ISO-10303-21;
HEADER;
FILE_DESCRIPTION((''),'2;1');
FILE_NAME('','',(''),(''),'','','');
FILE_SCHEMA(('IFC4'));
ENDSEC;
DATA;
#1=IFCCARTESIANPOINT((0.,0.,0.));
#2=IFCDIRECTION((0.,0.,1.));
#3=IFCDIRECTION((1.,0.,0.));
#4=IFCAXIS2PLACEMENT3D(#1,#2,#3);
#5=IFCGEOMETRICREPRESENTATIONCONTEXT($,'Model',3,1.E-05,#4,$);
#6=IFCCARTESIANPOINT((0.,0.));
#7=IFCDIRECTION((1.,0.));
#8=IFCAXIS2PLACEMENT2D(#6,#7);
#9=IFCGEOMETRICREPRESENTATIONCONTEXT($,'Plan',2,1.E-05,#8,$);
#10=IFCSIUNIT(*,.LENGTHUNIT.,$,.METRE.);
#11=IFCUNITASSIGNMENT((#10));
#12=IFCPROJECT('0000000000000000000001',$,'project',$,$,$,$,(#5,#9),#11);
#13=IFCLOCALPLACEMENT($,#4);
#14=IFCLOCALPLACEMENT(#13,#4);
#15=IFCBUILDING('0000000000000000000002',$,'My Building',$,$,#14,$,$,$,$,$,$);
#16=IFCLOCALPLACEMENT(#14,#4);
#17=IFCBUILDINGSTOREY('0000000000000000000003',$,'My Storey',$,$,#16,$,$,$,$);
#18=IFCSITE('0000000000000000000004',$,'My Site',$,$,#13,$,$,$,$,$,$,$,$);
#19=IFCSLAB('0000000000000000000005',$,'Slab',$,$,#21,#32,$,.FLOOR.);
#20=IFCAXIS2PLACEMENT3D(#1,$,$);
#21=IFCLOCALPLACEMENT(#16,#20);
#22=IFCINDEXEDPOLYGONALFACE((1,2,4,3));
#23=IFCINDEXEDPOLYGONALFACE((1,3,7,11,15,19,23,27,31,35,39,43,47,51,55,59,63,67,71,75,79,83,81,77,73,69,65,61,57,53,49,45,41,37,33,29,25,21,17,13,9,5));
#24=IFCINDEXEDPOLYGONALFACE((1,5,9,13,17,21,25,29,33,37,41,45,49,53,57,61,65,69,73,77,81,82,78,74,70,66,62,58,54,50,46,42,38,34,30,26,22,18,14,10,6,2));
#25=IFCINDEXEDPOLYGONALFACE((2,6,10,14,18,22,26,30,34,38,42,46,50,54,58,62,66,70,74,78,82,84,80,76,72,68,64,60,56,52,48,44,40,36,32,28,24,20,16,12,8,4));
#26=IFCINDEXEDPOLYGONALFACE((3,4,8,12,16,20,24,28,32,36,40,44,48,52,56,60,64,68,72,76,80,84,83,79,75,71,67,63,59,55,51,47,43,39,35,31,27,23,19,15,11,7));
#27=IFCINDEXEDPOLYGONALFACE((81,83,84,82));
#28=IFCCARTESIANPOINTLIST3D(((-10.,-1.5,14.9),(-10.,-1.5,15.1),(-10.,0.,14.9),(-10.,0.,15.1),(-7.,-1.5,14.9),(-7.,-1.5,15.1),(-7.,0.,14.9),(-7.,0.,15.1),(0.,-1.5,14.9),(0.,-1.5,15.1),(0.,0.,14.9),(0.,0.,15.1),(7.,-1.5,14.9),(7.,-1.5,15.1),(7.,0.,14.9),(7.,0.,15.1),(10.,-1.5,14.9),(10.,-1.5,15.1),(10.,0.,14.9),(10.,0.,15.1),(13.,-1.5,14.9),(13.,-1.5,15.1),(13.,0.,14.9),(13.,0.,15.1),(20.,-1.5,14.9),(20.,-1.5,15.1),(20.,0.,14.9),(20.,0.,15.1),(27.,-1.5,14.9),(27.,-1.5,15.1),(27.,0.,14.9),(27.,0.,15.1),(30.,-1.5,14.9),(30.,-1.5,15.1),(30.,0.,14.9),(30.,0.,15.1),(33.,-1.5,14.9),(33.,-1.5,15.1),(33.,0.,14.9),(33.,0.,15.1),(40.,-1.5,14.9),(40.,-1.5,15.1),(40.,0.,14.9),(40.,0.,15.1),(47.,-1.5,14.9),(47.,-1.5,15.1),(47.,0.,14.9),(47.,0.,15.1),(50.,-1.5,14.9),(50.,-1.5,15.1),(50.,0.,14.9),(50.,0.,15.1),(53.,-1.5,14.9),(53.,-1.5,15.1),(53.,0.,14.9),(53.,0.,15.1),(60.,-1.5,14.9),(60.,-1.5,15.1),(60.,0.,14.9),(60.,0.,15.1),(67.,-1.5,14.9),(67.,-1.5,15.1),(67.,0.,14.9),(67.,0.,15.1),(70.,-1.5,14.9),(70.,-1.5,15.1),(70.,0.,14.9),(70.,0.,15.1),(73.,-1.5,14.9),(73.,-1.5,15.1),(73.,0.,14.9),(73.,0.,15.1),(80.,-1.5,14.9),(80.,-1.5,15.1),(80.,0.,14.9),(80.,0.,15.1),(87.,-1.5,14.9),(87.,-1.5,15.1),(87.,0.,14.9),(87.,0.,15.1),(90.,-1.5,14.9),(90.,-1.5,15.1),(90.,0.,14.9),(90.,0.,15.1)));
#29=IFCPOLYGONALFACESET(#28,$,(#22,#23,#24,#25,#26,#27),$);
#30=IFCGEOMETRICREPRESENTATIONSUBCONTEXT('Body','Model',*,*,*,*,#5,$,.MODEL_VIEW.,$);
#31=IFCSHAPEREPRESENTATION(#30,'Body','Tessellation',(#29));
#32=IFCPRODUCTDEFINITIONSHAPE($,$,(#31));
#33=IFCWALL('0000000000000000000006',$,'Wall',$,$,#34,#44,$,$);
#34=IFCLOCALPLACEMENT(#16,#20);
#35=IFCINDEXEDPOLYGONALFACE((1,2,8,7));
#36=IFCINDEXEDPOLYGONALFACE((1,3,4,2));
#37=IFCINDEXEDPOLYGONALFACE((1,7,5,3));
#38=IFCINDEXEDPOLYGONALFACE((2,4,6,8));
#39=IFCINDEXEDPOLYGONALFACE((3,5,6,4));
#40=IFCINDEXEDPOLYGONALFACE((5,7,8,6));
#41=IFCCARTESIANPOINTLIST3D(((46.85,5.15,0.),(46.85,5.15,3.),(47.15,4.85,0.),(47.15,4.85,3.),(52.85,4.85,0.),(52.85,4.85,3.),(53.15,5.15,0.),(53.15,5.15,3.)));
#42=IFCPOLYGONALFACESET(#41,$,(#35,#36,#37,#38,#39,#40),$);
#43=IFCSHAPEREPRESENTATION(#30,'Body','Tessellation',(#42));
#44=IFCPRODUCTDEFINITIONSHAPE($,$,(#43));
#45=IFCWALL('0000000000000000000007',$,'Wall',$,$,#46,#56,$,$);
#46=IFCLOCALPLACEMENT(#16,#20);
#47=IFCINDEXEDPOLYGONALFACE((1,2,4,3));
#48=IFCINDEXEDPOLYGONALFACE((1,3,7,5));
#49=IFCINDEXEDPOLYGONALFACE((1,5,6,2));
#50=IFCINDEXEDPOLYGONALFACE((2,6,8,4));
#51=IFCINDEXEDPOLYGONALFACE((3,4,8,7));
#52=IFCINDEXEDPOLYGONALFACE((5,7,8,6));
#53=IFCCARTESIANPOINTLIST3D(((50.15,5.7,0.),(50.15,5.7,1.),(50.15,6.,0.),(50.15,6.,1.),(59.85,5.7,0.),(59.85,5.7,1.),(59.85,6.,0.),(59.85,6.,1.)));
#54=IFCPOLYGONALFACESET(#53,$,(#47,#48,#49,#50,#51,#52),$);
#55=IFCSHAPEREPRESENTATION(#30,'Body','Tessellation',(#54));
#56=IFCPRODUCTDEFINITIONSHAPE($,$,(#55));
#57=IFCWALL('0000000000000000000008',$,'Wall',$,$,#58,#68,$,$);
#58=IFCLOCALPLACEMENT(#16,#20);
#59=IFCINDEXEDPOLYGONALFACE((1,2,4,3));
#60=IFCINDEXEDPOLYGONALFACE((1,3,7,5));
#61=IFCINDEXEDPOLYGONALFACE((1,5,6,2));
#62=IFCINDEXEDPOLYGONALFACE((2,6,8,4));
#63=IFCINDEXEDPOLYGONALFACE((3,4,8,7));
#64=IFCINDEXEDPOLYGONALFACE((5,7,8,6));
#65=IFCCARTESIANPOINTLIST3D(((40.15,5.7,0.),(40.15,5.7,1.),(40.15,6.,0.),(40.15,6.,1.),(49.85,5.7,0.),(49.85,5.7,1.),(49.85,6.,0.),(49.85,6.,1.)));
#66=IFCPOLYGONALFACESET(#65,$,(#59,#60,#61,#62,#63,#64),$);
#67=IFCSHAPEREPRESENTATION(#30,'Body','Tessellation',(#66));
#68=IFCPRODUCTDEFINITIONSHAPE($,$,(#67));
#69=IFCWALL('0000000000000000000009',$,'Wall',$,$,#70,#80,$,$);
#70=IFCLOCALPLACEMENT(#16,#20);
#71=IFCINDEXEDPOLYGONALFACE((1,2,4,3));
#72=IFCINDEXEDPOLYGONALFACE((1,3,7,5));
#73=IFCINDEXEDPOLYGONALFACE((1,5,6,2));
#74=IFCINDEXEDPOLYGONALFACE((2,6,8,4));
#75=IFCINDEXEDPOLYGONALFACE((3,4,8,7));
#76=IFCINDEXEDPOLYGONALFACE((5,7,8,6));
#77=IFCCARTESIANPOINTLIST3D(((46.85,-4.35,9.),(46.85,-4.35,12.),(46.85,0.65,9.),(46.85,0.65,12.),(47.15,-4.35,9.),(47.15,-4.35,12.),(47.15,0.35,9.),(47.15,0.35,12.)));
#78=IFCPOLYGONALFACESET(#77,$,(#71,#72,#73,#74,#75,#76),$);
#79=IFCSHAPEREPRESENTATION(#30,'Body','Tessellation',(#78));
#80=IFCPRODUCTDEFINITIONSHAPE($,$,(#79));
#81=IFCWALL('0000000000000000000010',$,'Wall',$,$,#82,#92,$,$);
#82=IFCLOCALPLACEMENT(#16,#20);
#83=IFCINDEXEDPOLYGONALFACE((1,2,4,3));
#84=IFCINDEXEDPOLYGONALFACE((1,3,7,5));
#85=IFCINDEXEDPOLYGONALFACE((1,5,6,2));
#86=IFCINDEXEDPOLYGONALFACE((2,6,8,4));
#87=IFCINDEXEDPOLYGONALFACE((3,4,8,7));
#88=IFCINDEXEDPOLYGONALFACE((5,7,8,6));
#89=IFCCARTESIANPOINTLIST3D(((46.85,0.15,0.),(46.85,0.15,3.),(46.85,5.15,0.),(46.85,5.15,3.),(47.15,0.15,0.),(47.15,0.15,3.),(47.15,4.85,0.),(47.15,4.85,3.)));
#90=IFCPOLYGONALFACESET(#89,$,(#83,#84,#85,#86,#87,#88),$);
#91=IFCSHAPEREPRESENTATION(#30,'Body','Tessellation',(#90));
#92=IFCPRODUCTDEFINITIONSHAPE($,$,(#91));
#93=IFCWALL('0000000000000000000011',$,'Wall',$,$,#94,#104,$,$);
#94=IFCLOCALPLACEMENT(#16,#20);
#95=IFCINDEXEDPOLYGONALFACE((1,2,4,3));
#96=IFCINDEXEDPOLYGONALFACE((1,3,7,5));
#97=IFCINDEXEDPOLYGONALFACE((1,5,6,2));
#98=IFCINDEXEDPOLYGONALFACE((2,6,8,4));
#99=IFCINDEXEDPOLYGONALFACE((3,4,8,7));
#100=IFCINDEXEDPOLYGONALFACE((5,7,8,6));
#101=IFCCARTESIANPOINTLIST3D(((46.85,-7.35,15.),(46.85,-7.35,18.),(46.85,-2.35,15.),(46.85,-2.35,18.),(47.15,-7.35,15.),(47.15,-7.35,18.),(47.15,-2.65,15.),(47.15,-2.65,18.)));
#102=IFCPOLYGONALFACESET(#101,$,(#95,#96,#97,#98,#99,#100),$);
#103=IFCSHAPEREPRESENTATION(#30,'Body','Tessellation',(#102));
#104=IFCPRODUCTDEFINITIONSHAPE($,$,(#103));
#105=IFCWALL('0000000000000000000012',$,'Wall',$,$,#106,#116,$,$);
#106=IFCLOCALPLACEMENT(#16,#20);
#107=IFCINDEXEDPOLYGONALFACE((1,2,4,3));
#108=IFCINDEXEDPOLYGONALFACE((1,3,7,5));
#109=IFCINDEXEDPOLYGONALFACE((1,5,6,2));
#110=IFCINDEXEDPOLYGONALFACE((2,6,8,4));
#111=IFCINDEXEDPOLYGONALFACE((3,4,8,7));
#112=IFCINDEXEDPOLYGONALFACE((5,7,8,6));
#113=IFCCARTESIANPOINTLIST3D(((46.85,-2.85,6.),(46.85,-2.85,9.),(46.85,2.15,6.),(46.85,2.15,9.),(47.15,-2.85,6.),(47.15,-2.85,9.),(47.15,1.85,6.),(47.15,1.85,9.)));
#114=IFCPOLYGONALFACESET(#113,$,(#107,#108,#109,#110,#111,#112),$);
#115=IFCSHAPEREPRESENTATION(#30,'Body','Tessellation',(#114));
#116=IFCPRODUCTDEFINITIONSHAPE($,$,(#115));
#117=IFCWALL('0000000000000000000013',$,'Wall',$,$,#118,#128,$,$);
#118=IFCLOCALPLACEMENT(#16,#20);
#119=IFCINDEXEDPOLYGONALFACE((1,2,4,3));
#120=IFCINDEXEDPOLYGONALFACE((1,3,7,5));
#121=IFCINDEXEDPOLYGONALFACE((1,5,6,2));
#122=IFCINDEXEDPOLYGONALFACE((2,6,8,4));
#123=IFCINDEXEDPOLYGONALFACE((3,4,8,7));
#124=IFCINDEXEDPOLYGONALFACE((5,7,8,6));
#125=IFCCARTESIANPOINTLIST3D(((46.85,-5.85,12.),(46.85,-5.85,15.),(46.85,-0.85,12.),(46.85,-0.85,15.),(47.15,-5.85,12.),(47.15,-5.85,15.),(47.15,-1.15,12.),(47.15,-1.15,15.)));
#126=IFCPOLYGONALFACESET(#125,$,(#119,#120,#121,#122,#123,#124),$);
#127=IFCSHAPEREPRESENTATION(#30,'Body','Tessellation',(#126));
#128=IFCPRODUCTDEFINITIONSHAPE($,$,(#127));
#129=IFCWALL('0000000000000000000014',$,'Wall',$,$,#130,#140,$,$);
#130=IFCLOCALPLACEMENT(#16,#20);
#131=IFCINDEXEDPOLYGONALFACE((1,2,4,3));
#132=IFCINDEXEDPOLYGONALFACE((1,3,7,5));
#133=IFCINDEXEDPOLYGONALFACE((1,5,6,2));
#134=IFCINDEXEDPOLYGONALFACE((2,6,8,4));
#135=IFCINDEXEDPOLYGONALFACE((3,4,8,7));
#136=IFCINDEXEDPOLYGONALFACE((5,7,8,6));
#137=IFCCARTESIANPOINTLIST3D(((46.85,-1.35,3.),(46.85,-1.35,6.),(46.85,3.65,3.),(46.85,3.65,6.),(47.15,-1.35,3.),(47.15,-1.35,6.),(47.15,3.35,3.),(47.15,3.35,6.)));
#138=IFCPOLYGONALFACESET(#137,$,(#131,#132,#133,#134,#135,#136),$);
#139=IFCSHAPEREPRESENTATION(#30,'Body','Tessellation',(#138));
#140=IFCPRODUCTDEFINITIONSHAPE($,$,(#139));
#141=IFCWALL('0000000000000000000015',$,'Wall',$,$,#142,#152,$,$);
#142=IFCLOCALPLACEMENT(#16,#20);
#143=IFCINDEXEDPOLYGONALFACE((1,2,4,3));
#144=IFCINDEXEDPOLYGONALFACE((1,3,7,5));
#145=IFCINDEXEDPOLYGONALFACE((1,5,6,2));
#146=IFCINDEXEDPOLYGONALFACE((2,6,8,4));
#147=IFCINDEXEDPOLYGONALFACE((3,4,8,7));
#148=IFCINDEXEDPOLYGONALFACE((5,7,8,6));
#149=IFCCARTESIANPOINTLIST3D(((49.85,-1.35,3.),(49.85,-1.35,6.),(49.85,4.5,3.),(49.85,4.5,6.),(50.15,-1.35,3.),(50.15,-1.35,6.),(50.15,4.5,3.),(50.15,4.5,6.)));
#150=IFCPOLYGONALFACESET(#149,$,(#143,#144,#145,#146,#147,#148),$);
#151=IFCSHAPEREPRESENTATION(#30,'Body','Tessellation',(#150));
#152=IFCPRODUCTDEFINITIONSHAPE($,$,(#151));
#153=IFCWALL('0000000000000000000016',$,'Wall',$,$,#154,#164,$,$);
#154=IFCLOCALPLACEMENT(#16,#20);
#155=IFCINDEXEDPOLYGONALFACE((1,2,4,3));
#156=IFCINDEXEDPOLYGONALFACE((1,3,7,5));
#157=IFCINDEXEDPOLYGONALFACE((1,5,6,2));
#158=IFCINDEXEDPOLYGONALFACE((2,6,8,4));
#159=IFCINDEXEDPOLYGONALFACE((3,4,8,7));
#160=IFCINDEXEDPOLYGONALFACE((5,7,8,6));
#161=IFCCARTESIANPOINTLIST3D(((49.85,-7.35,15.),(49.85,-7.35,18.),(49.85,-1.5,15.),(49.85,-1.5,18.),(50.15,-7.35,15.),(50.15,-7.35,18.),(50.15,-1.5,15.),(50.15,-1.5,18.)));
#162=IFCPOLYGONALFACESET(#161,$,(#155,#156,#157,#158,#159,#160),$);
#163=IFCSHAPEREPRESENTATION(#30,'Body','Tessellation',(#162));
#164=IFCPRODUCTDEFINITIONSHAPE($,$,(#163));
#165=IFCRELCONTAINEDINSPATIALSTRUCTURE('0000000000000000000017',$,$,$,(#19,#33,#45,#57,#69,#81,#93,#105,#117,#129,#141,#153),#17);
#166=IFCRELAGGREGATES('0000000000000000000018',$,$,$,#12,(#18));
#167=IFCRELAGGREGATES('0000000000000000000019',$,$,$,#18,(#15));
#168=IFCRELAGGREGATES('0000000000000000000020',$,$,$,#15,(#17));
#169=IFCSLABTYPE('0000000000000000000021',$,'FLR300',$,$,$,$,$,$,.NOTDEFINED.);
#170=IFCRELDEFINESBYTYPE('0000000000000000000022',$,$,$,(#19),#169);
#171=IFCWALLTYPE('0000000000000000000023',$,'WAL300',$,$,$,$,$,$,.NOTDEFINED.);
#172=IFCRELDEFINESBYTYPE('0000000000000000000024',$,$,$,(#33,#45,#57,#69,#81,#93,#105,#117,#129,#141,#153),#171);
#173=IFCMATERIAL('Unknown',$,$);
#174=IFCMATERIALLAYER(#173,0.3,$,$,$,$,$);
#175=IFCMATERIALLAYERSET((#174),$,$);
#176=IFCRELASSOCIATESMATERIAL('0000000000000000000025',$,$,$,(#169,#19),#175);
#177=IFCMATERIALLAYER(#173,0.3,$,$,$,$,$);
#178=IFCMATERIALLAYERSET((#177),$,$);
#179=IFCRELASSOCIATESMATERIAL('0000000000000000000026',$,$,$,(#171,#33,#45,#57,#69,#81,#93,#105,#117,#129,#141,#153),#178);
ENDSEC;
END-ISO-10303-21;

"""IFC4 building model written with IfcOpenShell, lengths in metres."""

from ifc_helpers import new_model, si_unit, frame, origin, origin_with_axes, origin_2d_with_axis, place, context, subcontext, project, spatial, polyline, line, indexed_curve, outline, extrude, material, layer, layer_set, layer_usage, type_object, element, save


model = new_model("IFC4")

# Units and contexts
model_context = context("Model", 3, precision=1e-05, world=origin_with_axes())
plan_context = context("Plan", 2, precision=1e-05, world=origin_2d_with_axis())
body_context = subcontext(model_context, "Body", "Model", "MODEL_VIEW")
ifc_project = project(units=[si_unit("LENGTHUNIT", "METRE")], contexts=[model_context, plan_context])

# Site, building, storey
site_placement = place(None, origin_with_axes())
site = spatial("IfcSite", under=ifc_project, at=site_placement, Name="My Site")
building_placement = place(site_placement, origin_with_axes())
building = spatial("IfcBuilding", under=site, at=building_placement, Name="My Building")
storey_placement = place(building_placement, origin_with_axes())
storey = spatial("IfcBuildingStorey", under=building, at=storey_placement, Name="My Storey")

# Slab
ifc_material = material(Name="Unknown")
ifc_layer_1 = layer(ifc_material, 0.3)
ifc_layer_set_1 = layer_set([ifc_layer_1])
ifc_layer_usage_1 = layer_usage(ifc_layer_set_1, "AXIS3", "POSITIVE", 0.0)
slab_type = type_object("IfcSlabType", Name="FLR300", PredefinedType="NOTDEFINED", material=ifc_layer_set_1)
slab_placement = place(storey_placement, frame((40.0, -0.75, 14.9), z_axis=(0.0, 0.0, 1.0), x_axis=(1.0, 0.0, 0.0)))
element("IfcSlab", 1, at=slab_placement, inside=storey, type_object=slab_type, material=ifc_layer_usage_1, Name="Slab", PredefinedType="FLOOR", context=body_context, shape_type="SweptSolid", body=[
    extrude(outline(polyline([(-40.0, -0.75), (-33.0, -0.75), (-30.0, -0.75), (-27.0, -0.75), (-20.0, -0.75), (-13.0, -0.75), (-10.0, -0.75), (-7.0, -0.75), (0.0, -0.75), (7.0, -0.75), (10.0, -0.75), (13.0, -0.75), (20.0, -0.75), (27.0, -0.75), (30.0, -0.75), (33.0, -0.75), (40.0, -0.75), (47.0, -0.75), (50.0, -0.75), (50.0, 0.75), (47.0, 0.75), (40.0, 0.75), (33.0, 0.75), (30.0, 0.75), (27.0, 0.75), (20.0, 0.75), (13.0, 0.75), (10.0, 0.75), (7.0, 0.75), (0.0, 0.75), (-7.0, 0.75), (-10.0, 0.75), (-13.0, 0.75), (-20.0, 0.75), (-27.0, 0.75), (-30.0, 0.75), (-33.0, 0.75), (-40.0, 0.75), (-47.0, 0.75), (-50.0, 0.75), (-50.0, -0.75), (-47.0, -0.75), (-40.0, -0.75)])), origin(), (0.0, 0.0, 1.0), 0.2),
])

# Walls
ifc_layer_2 = layer(ifc_material, 0.3)
ifc_layer_set_2 = layer_set([ifc_layer_2])
ifc_layer_usage_2 = layer_usage(ifc_layer_set_2, "AXIS2", "POSITIVE", -0.15)
wall_type = type_object("IfcWallType", Name="WAL300", PredefinedType="NOTDEFINED", material=ifc_layer_set_2)
wall_1_placement = place(storey_placement, frame((47.0, 5.0, 0.0), z_axis=(0.0, 0.0, 1.0), x_axis=(1.0, 0.0, 0.0)))
element("IfcWall", 2, at=wall_1_placement, inside=storey, type_object=wall_type, material=ifc_layer_usage_2, Name="Wall", context=body_context, shape_type="SweptSolid", body=[
    extrude(outline(indexed_curve([(0.15, -0.15), (-0.15, 0.15), (6.15, 0.15), (5.85, -0.15)], segments=[line(1, 2, 3, 4, 1)])), origin_with_axes(), (0.0, 0.0, 1.0), 3.0),
])
ifc_layer_usage_3 = layer_usage(ifc_layer_set_2, "AXIS2", "POSITIVE", -0.3)
wall_2_placement = place(storey_placement, frame((50.15, 6.0, 0.0), z_axis=(0.0, 0.0, 1.0), x_axis=(1.0, 0.0, 0.0)))
element("IfcWall", 3, at=wall_2_placement, inside=storey, type_object=wall_type, material=ifc_layer_usage_3, Name="Wall", context=body_context, shape_type="SweptSolid", body=[
    extrude(outline(indexed_curve([(0.0, -0.3), (0.0, 0.0), (9.7, 0.0), (9.7, -0.3)], segments=[line(1, 2, 3, 4, 1)])), origin_with_axes(), (0.0, 0.0, 1.0), 1.0),
])
ifc_layer_usage_4 = layer_usage(ifc_layer_set_2, "AXIS2", "POSITIVE", -0.3)
wall_3_placement = place(storey_placement, frame((40.15, 6.0, 0.0), z_axis=(0.0, 0.0, 1.0), x_axis=(1.0, 0.0, 0.0)))
element("IfcWall", 4, at=wall_3_placement, inside=storey, type_object=wall_type, material=ifc_layer_usage_4, Name="Wall", context=body_context, shape_type="SweptSolid", body=[
    extrude(outline(indexed_curve([(0.0, -0.3), (0.0, 0.0), (9.7, 0.0), (9.7, -0.3)], segments=[line(1, 2, 3, 4, 1)])), origin_with_axes(), (0.0, 0.0, 1.0), 1.0),
])
ifc_layer_usage_5 = layer_usage(ifc_layer_set_2, "AXIS2", "POSITIVE", -0.15)
wall_4_placement = place(storey_placement, frame((47.0, 0.5, 9.0), z_axis=(0.0, 0.0, 1.0), x_axis=(0.0, -1.0, 0.0)))
element("IfcWall", 5, at=wall_4_placement, inside=storey, type_object=wall_type, material=ifc_layer_usage_5, Name="Wall", context=body_context, shape_type="SweptSolid", body=[
    extrude(outline(indexed_curve([(-0.15, -0.15), (0.15, 0.15), (4.85, 0.15), (4.85, -0.15)], segments=[line(1, 2, 3, 4, 1)])), origin_with_axes(), (0.0, 0.0, 1.0), 3.0),
])
ifc_layer_usage_6 = layer_usage(ifc_layer_set_2, "AXIS2", "POSITIVE", -0.15)
wall_5_placement = place(storey_placement, frame((47.0, 5.0, 0.0), z_axis=(0.0, 0.0, 1.0), x_axis=(0.0, -1.0, 0.0)))
element("IfcWall", 6, at=wall_5_placement, inside=storey, type_object=wall_type, material=ifc_layer_usage_6, Name="Wall", context=body_context, shape_type="SweptSolid", body=[
    extrude(outline(indexed_curve([(-0.15, -0.15), (0.15, 0.15), (4.85, 0.15), (4.85, -0.15)], segments=[line(1, 2, 3, 4, 1)])), origin_with_axes(), (0.0, 0.0, 1.0), 3.0),
])
ifc_layer_usage_7 = layer_usage(ifc_layer_set_2, "AXIS2", "POSITIVE", -0.15)
wall_6_placement = place(storey_placement, frame((47.0, -2.5, 15.0), z_axis=(0.0, 0.0, 1.0), x_axis=(0.0, -1.0, 0.0)))
element("IfcWall", 7, at=wall_6_placement, inside=storey, type_object=wall_type, material=ifc_layer_usage_7, Name="Wall", context=body_context, shape_type="SweptSolid", body=[
    extrude(outline(indexed_curve([(-0.15, -0.15), (0.15, 0.15), (4.85, 0.15), (4.85, -0.15)], segments=[line(1, 2, 3, 4, 1)])), origin_with_axes(), (0.0, 0.0, 1.0), 3.0),
])
ifc_layer_usage_8 = layer_usage(ifc_layer_set_2, "AXIS2", "POSITIVE", -0.15)
wall_7_placement = place(storey_placement, frame((47.0, 2.0, 6.0), z_axis=(0.0, 0.0, 1.0), x_axis=(0.0, -1.0, 0.0)))
element("IfcWall", 8, at=wall_7_placement, inside=storey, type_object=wall_type, material=ifc_layer_usage_8, Name="Wall", context=body_context, shape_type="SweptSolid", body=[
    extrude(outline(indexed_curve([(-0.15, -0.15), (0.15, 0.15), (4.85, 0.15), (4.85, -0.15)], segments=[line(1, 2, 3, 4, 1)])), origin_with_axes(), (0.0, 0.0, 1.0), 3.0),
])
ifc_layer_usage_9 = layer_usage(ifc_layer_set_2, "AXIS2", "POSITIVE", -0.15)
wall_8_placement = place(storey_placement, frame((47.0, -1.0, 12.0), z_axis=(0.0, 0.0, 1.0), x_axis=(0.0, -1.0, 0.0)))
element("IfcWall", 9, at=wall_8_placement, inside=storey, type_object=wall_type, material=ifc_layer_usage_9, Name="Wall", context=body_context, shape_type="SweptSolid", body=[
    extrude(outline(indexed_curve([(-0.15, -0.15), (0.15, 0.15), (4.85, 0.15), (4.85, -0.15)], segments=[line(1, 2, 3, 4, 1)])), origin_with_axes(), (0.0, 0.0, 1.0), 3.0),
])
ifc_layer_usage_10 = layer_usage(ifc_layer_set_2, "AXIS2", "POSITIVE", -0.15)
wall_9_placement = place(storey_placement, frame((47.0, 3.5, 3.0), z_axis=(0.0, 0.0, 1.0), x_axis=(0.0, -1.0, 0.0)))
element("IfcWall", 10, at=wall_9_placement, inside=storey, type_object=wall_type, material=ifc_layer_usage_10, Name="Wall", context=body_context, shape_type="SweptSolid", body=[
    extrude(outline(indexed_curve([(-0.15, -0.15), (0.15, 0.15), (4.85, 0.15), (4.85, -0.15)], segments=[line(1, 2, 3, 4, 1)])), origin_with_axes(), (0.0, 0.0, 1.0), 3.0),
])
ifc_layer_usage_11 = layer_usage(ifc_layer_set_2, "AXIS2", "POSITIVE", -0.15)
wall_10_placement = place(storey_placement, frame((50.0, 4.5, 3.0), z_axis=(0.0, 0.0, 1.0), x_axis=(0.0, -1.0, 0.0)))
element("IfcWall", 11, at=wall_10_placement, inside=storey, type_object=wall_type, material=ifc_layer_usage_11, Name="Wall", context=body_context, shape_type="SweptSolid", body=[
    extrude(outline(indexed_curve([(0.0, -0.15), (0.0, 0.15), (5.85, 0.15), (5.85, -0.15)], segments=[line(1, 2, 3, 4, 1)])), origin_with_axes(), (0.0, 0.0, 1.0), 3.0),
])
ifc_layer_usage_12 = layer_usage(ifc_layer_set_2, "AXIS2", "POSITIVE", -0.15)
wall_11_placement = place(storey_placement, frame((50.0, -1.5, 15.0), z_axis=(0.0, 0.0, 1.0), x_axis=(0.0, -1.0, 0.0)))
element("IfcWall", 12, at=wall_11_placement, inside=storey, type_object=wall_type, material=ifc_layer_usage_12, Name="Wall", context=body_context, shape_type="SweptSolid", body=[
    extrude(outline(indexed_curve([(0.0, -0.15), (0.0, 0.15), (5.85, 0.15), (5.85, -0.15)], segments=[line(1, 2, 3, 4, 1)])), origin_with_axes(), (0.0, 0.0, 1.0), 3.0),
])

save(model, "model.ifc")
